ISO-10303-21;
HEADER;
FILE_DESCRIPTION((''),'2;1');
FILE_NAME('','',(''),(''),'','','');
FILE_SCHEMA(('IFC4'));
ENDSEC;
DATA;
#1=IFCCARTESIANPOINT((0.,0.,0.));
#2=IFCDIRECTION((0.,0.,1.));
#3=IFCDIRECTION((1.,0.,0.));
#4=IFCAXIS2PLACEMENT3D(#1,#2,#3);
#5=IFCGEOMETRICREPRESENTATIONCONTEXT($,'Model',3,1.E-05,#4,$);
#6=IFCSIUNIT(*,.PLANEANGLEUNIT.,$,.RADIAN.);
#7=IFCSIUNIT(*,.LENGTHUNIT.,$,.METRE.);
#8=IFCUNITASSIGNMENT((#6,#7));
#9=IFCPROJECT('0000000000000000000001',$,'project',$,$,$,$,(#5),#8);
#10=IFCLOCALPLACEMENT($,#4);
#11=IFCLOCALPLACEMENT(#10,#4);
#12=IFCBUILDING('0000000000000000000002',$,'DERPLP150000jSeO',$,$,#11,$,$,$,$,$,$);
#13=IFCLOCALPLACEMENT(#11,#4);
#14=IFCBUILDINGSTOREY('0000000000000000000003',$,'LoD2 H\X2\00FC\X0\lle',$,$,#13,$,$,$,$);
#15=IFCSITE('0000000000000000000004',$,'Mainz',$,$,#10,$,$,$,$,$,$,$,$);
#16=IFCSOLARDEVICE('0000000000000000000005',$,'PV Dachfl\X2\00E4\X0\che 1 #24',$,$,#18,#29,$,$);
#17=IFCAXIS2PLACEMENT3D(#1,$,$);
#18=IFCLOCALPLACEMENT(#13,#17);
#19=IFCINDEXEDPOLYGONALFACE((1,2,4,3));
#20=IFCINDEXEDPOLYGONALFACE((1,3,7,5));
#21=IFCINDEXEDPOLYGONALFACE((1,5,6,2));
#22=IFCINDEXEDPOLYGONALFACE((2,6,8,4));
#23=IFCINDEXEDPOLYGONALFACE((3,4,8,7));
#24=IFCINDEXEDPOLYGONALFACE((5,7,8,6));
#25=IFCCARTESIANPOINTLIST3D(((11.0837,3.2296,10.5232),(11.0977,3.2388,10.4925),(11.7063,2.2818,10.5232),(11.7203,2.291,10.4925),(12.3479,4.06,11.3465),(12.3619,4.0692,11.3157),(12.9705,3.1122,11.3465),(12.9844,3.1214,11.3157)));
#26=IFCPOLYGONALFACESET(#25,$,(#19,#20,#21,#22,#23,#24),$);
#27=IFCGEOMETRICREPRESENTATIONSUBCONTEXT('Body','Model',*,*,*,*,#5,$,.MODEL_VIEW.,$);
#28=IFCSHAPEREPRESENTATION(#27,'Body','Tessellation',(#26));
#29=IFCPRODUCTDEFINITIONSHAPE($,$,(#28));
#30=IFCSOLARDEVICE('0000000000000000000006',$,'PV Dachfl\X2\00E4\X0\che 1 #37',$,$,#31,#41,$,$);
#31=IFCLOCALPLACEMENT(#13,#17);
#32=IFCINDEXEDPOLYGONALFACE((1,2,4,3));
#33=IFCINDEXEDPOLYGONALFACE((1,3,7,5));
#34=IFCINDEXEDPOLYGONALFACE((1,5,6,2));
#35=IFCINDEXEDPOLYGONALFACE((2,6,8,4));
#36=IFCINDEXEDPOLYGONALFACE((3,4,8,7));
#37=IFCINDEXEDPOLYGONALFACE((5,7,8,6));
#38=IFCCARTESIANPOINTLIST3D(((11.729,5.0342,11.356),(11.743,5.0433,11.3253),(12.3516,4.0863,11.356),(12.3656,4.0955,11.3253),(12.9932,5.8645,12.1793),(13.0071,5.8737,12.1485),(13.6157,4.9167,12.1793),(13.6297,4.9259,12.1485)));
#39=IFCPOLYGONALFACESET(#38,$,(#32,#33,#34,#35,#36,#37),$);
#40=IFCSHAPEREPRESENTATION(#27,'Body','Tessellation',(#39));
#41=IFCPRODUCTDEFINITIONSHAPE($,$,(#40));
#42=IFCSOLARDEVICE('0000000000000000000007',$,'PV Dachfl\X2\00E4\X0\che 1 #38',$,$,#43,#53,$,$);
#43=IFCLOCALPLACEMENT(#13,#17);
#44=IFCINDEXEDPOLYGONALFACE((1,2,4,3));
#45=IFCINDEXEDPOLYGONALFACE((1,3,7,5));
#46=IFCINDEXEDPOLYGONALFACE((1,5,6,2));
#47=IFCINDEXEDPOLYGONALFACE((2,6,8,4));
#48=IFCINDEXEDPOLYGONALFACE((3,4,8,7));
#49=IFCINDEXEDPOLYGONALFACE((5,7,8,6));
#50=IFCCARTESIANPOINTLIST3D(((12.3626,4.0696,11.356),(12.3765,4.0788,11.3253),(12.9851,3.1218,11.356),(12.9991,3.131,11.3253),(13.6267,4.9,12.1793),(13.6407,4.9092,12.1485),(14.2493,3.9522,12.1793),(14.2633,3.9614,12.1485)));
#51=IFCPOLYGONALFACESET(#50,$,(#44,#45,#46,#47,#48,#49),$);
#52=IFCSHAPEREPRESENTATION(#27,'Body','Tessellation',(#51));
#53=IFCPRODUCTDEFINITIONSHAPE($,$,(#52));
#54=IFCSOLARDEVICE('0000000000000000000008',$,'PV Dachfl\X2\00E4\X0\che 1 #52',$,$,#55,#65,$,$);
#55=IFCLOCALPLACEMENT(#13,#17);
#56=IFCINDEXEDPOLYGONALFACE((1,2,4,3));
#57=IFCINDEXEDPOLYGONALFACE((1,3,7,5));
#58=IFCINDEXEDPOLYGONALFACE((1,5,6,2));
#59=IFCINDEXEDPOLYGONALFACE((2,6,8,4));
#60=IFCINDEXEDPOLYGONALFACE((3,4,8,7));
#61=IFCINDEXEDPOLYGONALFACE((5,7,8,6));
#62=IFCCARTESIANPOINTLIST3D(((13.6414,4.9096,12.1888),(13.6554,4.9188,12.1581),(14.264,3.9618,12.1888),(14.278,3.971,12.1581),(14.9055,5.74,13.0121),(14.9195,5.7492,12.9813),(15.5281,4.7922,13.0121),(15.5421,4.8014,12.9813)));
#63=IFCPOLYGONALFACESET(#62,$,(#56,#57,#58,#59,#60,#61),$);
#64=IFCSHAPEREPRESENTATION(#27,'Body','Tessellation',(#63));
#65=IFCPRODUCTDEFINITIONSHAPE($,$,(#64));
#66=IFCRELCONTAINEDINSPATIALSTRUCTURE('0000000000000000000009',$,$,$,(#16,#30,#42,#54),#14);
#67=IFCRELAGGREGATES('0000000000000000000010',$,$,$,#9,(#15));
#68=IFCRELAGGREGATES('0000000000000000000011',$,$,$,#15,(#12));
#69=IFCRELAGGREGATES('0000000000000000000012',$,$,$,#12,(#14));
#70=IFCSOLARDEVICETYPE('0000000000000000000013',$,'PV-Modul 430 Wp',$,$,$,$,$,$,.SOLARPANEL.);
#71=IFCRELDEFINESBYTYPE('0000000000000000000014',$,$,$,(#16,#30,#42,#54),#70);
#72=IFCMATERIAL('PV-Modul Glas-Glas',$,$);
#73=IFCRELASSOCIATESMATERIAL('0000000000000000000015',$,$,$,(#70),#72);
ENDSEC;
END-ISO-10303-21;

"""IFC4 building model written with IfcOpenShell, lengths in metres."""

from ifc_helpers import new_model, si_unit, frame, frame_2d, origin, origin_with_axes, place, context, subcontext, project, spatial, rectangle, extrude, source, transform, mapped, material, type_object, type_shapes, element, save


model = new_model("IFC4")

# Units and contexts
model_context = context("Model", 3, precision=1e-05, world=origin_with_axes())
body_context = subcontext(model_context, "Body", "Model", "MODEL_VIEW")
ifc_project = project(units=[si_unit("PLANEANGLEUNIT", "RADIAN"), si_unit("LENGTHUNIT", "METRE")], contexts=[model_context])

# Site, building, storey
site_placement = place(None, origin_with_axes())
site = spatial("IfcSite", under=ifc_project, at=site_placement, Name="Mainz")
building_placement = place(site_placement, origin_with_axes())
building = spatial("IfcBuilding", under=site, at=building_placement, Name="DERPLP150000jSeO")
storey_placement = place(building_placement, origin_with_axes())
storey = spatial("IfcBuildingStorey", under=building, at=storey_placement, Name="LoD2 Hülle")

# Solar devices
ifc_material_1 = material(Name="PV-Modul Glas-Glas")
solar_device_type = type_object("IfcSolarDeviceType", Name="PV-Modul 430 Wp", PredefinedType="SOLARPANEL", material=ifc_material_1)
shared_shape = source(origin_with_axes(), body_context, "Body", "SweptSolid", [
    extrude(rectangle(XDim=1.722, YDim=1.134, at=frame_2d((0.861, 0.567))), origin(), (0.0, 0.0, 1.0), 0.035),
])
type_shapes(solar_device_type, [shared_shape])
for number, where, z_axis, x_axis, name in (
    (1, (11.7203, 2.291, 10.4925), (-0.399585, -0.262469, 0.878318), (0.734113, 0.482204, 0.478077), "PV Dachfläche 1 #24"),
    (2, (12.3656, 4.0955, 11.3253), (-0.399585, -0.262469, 0.878318), (0.734113, 0.482204, 0.478077), "PV Dachfläche 1 #37"),
    (3, (12.9991, 3.131, 11.3253), (-0.399585, -0.262469, 0.878318), (0.734113, 0.482204, 0.478077), "PV Dachfläche 1 #38"),
    (4, (14.278, 3.971, 12.1581), (-0.399585, -0.262469, 0.878318), (0.734113, 0.482204, 0.478077), "PV Dachfläche 1 #52"),
):
    element("IfcSolarDevice", number, at=place(storey_placement, frame(where, z_axis=z_axis, x_axis=x_axis)), inside=storey, type_object=solar_device_type, Name=name, context=body_context, shape_type="MappedRepresentation", body=[
        mapped(shared_shape, transform((0.0, 0.0, 0.0), x_axis=(1.0, 0.0, 0.0), y_axis=(0.0, 1.0, 0.0), z_axis=(0.0, 0.0, 1.0), scale=1.0)),
    ])

save(model, "model.ifc")
